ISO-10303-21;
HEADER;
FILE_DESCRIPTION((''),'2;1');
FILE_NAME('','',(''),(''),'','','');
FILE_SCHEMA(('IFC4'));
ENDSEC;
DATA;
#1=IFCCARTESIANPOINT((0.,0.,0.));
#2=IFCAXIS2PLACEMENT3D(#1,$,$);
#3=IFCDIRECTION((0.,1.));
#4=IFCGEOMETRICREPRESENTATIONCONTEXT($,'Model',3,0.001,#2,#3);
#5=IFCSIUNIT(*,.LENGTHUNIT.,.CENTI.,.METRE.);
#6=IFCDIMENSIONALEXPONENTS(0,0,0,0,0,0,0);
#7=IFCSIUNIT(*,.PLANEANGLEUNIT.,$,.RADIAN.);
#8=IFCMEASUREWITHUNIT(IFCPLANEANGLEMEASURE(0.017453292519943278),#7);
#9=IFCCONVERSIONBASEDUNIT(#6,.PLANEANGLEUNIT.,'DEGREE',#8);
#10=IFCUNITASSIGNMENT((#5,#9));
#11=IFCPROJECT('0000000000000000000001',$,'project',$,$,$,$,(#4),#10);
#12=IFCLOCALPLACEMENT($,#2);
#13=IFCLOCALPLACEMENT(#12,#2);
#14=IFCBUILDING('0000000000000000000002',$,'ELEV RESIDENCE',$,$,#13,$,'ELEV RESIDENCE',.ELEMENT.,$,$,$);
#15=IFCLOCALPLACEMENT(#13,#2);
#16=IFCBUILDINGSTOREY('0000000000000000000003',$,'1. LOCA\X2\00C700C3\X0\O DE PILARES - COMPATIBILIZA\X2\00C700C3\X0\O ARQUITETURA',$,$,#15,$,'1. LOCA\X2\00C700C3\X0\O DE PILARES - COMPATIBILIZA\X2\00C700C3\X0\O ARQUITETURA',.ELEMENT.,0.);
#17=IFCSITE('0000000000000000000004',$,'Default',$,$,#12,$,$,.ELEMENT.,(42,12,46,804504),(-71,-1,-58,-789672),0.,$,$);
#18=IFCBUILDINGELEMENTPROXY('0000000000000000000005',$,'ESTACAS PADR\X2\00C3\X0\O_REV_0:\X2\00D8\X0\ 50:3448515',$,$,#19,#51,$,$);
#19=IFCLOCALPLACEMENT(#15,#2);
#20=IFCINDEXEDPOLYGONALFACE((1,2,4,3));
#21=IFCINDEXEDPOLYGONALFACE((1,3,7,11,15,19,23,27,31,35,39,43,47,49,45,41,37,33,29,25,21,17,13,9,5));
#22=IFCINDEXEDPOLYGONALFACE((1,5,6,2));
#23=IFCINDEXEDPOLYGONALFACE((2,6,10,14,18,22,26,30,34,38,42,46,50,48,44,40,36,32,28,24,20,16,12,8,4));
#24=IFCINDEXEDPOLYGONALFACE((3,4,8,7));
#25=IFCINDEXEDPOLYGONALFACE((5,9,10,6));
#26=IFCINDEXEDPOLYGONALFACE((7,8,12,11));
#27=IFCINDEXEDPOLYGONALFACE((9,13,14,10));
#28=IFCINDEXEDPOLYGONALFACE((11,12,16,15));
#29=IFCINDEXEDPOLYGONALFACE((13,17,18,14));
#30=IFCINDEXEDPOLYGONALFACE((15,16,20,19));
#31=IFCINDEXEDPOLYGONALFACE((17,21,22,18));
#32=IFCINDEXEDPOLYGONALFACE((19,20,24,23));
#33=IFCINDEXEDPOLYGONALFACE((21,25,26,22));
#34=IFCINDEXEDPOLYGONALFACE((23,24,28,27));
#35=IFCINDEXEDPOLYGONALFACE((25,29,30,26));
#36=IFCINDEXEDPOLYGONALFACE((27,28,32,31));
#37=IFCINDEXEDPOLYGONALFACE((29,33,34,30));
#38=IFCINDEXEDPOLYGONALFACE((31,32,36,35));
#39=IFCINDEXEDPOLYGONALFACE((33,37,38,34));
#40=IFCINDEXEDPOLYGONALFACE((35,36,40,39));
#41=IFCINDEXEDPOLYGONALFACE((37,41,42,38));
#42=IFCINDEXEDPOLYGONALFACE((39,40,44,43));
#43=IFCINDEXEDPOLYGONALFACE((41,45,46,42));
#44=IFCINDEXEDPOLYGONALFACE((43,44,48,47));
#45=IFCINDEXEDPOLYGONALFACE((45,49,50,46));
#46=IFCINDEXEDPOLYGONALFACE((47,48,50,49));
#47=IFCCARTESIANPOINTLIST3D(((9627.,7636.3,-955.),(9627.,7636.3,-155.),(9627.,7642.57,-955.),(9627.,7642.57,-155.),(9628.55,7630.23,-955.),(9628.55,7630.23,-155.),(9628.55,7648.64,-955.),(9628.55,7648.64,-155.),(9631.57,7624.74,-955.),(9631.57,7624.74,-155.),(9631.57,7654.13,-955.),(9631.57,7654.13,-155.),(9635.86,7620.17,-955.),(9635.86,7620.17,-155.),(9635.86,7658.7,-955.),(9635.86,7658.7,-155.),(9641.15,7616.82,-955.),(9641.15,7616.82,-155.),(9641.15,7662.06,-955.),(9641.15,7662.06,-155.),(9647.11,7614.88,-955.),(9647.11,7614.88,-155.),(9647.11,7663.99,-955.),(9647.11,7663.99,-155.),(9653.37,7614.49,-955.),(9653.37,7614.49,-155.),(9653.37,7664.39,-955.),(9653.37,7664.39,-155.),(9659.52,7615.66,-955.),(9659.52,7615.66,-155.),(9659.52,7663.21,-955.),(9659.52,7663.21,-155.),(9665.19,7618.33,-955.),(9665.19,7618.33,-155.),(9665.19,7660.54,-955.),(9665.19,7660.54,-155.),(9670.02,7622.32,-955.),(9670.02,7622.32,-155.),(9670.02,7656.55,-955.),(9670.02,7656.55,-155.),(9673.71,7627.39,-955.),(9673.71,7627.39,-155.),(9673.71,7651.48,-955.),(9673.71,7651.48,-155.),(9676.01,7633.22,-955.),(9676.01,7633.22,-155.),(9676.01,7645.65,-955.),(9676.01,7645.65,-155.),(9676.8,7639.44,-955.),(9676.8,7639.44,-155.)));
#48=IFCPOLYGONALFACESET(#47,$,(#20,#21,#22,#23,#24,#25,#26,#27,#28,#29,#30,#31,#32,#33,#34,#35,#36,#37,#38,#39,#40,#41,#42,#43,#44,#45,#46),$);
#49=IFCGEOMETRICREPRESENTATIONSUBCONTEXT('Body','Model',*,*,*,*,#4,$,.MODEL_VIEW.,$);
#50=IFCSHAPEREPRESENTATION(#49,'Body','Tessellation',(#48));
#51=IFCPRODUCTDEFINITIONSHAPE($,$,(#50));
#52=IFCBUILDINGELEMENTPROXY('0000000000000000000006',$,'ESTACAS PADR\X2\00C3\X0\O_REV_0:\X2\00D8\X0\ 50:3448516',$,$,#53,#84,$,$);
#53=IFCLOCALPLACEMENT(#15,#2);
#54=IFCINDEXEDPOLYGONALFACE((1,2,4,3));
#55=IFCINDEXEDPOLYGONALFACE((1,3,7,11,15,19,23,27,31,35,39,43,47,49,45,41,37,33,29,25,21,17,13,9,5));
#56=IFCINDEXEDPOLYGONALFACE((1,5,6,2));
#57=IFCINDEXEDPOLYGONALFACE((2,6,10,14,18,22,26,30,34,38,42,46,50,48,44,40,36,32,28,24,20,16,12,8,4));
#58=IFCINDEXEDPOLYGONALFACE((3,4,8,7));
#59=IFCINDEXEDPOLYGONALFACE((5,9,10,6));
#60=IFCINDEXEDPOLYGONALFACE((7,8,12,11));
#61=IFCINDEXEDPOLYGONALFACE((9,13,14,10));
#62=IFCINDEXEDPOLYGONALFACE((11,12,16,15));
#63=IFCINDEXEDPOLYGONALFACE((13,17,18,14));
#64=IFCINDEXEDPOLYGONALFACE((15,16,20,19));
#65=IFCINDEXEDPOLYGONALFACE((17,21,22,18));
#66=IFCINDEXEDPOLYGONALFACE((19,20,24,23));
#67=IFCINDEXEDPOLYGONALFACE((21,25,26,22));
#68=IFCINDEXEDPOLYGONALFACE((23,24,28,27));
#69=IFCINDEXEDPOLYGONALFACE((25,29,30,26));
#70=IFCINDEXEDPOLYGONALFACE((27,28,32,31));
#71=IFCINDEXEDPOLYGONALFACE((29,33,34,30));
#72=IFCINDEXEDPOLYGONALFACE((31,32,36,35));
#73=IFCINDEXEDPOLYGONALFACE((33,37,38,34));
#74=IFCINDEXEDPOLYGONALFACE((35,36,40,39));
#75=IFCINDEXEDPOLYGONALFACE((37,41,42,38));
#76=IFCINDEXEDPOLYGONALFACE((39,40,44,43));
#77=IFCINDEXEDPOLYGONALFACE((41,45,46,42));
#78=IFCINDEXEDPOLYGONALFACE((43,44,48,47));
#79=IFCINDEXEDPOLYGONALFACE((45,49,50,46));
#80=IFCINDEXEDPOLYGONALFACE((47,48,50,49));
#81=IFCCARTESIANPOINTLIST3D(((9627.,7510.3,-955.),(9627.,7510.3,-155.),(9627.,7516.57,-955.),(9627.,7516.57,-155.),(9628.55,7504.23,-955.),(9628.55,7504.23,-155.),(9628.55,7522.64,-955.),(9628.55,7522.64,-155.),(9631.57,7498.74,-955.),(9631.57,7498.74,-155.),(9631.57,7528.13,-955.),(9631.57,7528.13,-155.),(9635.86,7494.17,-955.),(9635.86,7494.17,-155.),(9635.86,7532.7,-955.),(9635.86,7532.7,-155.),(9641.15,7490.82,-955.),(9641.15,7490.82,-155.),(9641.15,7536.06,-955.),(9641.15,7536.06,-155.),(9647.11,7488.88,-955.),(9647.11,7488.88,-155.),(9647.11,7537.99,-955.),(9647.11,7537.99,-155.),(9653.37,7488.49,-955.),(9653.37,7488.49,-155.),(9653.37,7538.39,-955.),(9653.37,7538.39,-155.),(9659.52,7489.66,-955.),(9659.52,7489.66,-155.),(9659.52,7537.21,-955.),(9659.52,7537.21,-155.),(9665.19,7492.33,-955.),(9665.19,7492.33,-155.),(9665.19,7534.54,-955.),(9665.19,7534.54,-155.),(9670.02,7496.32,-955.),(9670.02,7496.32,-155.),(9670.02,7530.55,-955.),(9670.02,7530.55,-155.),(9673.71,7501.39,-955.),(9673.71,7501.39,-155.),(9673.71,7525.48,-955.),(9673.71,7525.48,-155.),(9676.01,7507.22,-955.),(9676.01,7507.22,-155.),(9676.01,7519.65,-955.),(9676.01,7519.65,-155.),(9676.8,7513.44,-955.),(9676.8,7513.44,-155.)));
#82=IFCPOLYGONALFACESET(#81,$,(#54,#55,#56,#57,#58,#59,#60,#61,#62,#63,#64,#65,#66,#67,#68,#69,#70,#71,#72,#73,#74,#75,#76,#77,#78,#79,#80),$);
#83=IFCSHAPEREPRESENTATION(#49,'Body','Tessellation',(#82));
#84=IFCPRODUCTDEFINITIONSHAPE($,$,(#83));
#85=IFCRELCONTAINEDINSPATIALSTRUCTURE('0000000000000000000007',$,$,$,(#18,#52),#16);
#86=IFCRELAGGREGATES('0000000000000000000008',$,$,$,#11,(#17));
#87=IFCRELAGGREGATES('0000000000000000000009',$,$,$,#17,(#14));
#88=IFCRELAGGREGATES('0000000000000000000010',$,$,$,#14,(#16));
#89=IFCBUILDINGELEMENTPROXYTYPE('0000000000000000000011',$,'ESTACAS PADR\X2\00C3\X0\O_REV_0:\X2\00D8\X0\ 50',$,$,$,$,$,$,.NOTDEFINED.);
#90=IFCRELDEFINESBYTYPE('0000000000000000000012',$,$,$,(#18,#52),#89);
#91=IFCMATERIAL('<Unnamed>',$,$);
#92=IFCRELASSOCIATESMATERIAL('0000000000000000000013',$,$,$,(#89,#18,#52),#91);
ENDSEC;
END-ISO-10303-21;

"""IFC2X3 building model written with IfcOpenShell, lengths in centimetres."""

from ifc_helpers import new_model, entity, si_unit, converted_unit, direction, frame, frame_2d, origin, place, context, subcontext, project, spatial, circle, extrude, source, transform, mapped, material, type_object, type_shapes, element, save


model = new_model("IFC2X3")

# Units and contexts
model_context = context("Model", 3, precision=0.001, world=origin(), true_north=direction((0.0, 1.0)))
body_context = subcontext(model_context, "Body", "Model", "MODEL_VIEW")
ifc_project = project(units=[si_unit("LENGTHUNIT", "METRE", prefix="CENTI"), converted_unit("PLANEANGLEUNIT", "DEGREE", entity("IfcPlaneAngleMeasure", 0.017453292519943278), si_unit("PLANEANGLEUNIT", "RADIAN"), dimensions=[0, 0, 0, 0, 0, 0, 0])], contexts=[model_context])

# Site, building, storey
site_placement = place(None, origin())
site = spatial("IfcSite", under=ifc_project, at=site_placement, Name="Default", CompositionType="ELEMENT", RefLatitude=(42, 12, 46, 804504), RefLongitude=(-71, -1, -58, -789672), RefElevation=0.0)
building_placement = place(site_placement, origin())
building = spatial("IfcBuilding", under=site, at=building_placement, Name="ELEV RESIDENCE", LongName="ELEV RESIDENCE", CompositionType="ELEMENT")
storey_placement = place(building_placement, origin())
storey = spatial("IfcBuildingStorey", under=building, at=storey_placement, Name="1. LOCAÇÃO DE PILARES - COMPATIBILIZAÇÃO ARQUITETURA", LongName="1. LOCAÇÃO DE PILARES - COMPATIBILIZAÇÃO ARQUITETURA", CompositionType="ELEMENT", Elevation=0.0)

# Building element proxies
ifc_material_1 = material(Name="<Unnamed>")
building_element_proxy_type_1 = type_object("IfcBuildingElementProxyType", Name="ESTACAS PADRÃO_REV_0:Ø 50", PredefinedType="NOTDEFINED", material=ifc_material_1)
shared_shape_1 = source(origin(), body_context, "Body", "SweptSolid", [
    extrude(circle(Radius=25.0, at=frame_2d((0.0, 0.0), x_axis=(1.0, 0.0))), frame((0.0, 0.0, -955.0)), (0.0, 0.0, 1.0), 800.0),
])
type_shapes(building_element_proxy_type_1, [shared_shape_1])
for number, where, name in (
    (1, (9651.8, 7639.44, 0.0), "ESTACAS PADRÃO_REV_0:Ø 50:3448515"),
    (2, (9651.8, 7513.44, 0.0), "ESTACAS PADRÃO_REV_0:Ø 50:3448516"),
):
    element("IfcBuildingElementProxy", number, at=place(storey_placement, frame(where)), inside=storey, type_object=building_element_proxy_type_1, material=ifc_material_1, Name=name, context=body_context, shape_type="MappedRepresentation", body=[
        mapped(shared_shape_1, transform((0.0, 0.0, 0.0), scale=1.0)),
    ])

save(model, "model.ifc")
